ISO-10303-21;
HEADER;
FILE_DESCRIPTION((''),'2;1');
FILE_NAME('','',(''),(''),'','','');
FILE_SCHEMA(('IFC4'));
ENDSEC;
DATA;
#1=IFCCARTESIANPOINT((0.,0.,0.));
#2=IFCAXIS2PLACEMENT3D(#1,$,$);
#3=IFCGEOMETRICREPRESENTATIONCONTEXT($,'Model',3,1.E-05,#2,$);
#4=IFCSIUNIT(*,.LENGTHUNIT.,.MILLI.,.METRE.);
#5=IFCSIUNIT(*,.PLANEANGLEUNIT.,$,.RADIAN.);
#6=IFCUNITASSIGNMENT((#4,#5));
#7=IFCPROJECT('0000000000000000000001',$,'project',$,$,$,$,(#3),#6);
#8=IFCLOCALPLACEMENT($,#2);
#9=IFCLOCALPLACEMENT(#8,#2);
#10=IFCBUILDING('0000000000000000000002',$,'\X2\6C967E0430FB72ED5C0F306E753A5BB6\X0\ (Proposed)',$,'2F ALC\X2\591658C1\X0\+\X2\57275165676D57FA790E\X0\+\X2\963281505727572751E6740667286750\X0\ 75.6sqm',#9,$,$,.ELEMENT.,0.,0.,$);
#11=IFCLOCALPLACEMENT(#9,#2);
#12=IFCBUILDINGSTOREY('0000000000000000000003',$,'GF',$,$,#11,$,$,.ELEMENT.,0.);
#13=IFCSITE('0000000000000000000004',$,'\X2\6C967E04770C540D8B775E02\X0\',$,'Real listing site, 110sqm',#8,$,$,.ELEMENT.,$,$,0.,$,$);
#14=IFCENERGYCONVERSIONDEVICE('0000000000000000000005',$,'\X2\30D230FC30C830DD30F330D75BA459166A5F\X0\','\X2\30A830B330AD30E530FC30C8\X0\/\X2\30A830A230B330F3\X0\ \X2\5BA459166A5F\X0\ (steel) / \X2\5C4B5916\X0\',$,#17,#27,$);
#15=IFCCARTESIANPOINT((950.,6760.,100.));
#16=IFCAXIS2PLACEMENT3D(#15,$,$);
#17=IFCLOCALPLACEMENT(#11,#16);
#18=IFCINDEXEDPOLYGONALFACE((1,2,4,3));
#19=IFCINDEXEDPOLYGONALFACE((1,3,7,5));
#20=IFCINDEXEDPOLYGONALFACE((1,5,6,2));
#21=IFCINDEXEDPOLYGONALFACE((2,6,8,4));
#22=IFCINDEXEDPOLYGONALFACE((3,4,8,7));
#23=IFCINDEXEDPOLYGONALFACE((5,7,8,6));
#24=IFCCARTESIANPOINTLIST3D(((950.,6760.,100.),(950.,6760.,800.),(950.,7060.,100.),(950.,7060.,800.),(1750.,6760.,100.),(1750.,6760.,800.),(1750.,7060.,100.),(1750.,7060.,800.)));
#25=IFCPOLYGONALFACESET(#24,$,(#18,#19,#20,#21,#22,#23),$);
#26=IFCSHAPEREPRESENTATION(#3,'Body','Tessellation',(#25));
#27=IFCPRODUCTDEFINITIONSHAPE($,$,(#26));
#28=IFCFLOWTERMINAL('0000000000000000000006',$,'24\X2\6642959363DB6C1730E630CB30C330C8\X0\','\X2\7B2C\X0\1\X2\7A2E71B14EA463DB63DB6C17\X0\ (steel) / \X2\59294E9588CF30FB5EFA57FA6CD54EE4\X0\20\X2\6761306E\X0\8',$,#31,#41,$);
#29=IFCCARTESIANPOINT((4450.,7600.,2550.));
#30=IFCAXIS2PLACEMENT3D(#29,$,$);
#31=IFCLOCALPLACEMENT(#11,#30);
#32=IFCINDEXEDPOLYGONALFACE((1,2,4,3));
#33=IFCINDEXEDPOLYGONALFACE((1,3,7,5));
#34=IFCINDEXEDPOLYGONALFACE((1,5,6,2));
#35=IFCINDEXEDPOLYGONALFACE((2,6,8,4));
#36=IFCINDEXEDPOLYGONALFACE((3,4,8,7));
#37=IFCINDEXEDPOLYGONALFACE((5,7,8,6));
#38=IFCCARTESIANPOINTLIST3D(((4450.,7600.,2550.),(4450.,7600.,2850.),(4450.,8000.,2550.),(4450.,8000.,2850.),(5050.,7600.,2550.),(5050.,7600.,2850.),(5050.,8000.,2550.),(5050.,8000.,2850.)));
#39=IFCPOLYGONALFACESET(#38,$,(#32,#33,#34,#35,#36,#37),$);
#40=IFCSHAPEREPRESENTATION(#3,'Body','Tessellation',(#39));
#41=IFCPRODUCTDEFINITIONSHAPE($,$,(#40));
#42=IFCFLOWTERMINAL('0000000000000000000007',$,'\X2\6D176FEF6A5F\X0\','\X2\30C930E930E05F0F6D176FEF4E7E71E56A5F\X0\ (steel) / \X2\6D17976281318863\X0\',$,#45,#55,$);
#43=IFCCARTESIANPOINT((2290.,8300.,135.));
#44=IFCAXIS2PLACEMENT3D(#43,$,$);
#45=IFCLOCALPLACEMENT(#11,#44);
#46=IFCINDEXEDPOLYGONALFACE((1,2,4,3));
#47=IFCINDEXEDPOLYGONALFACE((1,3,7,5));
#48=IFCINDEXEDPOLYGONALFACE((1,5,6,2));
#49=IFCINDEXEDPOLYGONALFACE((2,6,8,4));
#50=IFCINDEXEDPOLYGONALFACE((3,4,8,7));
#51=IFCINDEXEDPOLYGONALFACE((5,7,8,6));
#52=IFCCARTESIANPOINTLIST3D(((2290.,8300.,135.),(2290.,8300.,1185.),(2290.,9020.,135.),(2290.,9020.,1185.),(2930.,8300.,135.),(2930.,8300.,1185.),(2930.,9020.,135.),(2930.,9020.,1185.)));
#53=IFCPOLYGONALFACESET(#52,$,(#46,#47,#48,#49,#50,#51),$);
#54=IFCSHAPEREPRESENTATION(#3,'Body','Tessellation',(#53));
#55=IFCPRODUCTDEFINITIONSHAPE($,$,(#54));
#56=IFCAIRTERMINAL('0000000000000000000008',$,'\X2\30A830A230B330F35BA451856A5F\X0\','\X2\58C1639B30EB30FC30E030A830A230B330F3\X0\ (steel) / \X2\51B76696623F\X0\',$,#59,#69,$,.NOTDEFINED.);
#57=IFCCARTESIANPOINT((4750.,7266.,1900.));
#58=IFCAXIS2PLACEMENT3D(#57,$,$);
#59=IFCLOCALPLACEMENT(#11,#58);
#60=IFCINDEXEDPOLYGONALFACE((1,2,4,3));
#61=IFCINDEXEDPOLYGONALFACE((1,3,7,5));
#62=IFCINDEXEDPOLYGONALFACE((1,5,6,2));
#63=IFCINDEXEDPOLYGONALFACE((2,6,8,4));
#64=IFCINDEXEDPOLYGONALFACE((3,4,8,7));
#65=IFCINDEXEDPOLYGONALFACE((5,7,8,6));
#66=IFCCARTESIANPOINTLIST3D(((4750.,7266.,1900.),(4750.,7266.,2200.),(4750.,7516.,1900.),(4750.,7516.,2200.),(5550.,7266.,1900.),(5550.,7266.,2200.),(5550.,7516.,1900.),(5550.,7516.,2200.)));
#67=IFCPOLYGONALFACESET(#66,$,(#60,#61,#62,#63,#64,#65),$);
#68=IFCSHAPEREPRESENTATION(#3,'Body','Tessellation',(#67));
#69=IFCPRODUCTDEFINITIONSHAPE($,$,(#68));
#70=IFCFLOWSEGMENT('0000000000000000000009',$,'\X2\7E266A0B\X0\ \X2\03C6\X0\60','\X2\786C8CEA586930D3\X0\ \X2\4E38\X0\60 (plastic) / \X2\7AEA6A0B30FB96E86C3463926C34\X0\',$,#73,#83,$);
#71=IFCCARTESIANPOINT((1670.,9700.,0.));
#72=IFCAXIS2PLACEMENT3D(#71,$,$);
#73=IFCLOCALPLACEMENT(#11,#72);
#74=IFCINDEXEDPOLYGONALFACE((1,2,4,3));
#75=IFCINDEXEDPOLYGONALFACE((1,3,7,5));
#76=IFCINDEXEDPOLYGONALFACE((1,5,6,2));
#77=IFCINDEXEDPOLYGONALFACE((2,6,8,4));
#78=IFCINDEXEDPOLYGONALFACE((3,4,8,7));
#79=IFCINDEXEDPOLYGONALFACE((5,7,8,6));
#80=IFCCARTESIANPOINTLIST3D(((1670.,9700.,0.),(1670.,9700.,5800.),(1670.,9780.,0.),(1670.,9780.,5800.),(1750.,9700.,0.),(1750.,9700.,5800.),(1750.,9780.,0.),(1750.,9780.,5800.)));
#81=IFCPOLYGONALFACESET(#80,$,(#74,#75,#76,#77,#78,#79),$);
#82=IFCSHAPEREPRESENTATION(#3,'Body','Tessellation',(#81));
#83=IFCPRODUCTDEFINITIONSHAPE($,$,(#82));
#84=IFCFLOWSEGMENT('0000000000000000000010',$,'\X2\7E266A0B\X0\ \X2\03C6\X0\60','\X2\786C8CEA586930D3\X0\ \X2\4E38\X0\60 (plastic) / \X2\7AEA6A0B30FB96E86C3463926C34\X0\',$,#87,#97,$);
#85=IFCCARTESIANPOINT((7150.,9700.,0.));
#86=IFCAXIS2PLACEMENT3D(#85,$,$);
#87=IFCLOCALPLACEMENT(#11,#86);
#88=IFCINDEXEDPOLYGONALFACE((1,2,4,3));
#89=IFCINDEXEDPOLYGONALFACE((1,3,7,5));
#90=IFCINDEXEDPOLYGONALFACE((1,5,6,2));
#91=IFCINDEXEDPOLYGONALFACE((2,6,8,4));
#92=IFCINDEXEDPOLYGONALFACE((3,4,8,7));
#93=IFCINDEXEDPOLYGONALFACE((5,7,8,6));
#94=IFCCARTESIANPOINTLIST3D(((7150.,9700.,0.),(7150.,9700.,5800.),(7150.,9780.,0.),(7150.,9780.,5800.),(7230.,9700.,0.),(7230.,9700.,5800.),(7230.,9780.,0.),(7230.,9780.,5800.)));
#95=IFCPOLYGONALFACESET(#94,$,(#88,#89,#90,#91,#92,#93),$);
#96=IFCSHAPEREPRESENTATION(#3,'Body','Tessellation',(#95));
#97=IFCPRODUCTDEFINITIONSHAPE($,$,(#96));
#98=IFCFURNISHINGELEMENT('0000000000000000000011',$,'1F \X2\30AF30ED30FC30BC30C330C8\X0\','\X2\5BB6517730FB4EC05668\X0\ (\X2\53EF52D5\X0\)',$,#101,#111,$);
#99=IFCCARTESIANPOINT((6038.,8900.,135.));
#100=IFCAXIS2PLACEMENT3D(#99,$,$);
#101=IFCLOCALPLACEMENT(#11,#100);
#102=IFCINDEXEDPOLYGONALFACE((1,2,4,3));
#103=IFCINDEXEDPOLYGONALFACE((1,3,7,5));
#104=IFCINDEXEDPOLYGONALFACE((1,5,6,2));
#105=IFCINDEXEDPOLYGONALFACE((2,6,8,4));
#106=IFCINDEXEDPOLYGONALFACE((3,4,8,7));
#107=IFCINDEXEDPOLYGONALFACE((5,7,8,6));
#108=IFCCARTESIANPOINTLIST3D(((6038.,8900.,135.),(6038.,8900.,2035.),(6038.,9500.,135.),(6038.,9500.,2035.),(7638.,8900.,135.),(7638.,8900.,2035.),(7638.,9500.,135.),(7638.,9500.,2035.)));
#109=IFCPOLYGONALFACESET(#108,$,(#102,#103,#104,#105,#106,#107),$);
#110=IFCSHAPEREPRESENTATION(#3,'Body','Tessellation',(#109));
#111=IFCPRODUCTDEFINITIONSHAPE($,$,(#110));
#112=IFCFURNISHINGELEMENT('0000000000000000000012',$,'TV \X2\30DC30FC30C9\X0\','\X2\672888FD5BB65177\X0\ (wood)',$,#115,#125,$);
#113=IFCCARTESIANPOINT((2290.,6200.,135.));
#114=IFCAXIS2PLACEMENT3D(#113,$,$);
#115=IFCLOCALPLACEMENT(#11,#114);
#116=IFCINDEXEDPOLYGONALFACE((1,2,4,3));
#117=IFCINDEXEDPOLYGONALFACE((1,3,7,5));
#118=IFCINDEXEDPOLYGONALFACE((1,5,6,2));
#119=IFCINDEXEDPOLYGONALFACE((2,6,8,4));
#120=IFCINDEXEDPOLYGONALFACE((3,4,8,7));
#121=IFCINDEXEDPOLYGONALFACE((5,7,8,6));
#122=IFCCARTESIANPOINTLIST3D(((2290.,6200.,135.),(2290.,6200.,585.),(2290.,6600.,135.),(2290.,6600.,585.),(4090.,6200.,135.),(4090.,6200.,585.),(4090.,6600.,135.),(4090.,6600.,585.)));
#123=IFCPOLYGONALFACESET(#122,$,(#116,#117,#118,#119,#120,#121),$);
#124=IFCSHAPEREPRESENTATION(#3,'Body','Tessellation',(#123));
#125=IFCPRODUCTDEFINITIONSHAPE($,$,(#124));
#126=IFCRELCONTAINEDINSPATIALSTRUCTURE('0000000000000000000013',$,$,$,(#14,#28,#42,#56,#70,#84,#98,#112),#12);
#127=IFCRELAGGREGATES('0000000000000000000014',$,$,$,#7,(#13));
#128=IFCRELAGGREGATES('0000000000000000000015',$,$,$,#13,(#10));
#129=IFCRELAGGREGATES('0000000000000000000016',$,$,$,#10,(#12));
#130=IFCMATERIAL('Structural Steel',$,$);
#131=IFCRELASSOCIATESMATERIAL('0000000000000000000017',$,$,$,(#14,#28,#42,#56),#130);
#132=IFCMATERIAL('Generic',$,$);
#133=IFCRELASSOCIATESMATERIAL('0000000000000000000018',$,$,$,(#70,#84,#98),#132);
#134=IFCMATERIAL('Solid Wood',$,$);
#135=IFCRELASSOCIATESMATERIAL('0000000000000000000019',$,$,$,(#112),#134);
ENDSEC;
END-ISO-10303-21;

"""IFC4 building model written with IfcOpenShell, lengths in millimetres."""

from ifc_helpers import new_model, si_unit, frame, frame_2d, origin, place, context, project, spatial, rectangle, extrude, material, element, save


model = new_model("IFC4")

# Units and contexts
model_context = context("Model", 3, precision=1e-05, world=origin())
ifc_project = project(units=[si_unit("LENGTHUNIT", "METRE", prefix="MILLI"), si_unit("PLANEANGLEUNIT", "RADIAN")], contexts=[model_context])

# Site, building, storey
site_placement = place(None, origin())
site = spatial("IfcSite", under=ifc_project, at=site_placement, Name="沖縄県名護市", ObjectType="Real listing site, 110sqm", CompositionType="ELEMENT", RefElevation=0.0)
building_placement = place(site_placement, origin())
building = spatial("IfcBuilding", under=site, at=building_placement, Name="沖縄・狭小の町家 (Proposed)", ObjectType="2F ALC外壁+圧入杭基礎+防腐圧圧処理木材 75.6sqm", CompositionType="ELEMENT", ElevationOfRefHeight=0.0, ElevationOfTerrain=0.0)
storey_placement = place(building_placement, origin())
storey = spatial("IfcBuildingStorey", under=building, at=storey_placement, Name="GF", CompositionType="ELEMENT", Elevation=0.0)

# Shared definitions
ifc_material_1 = material(Name="Solid Wood")

# Shared definitions
ifc_material_2 = material(Name="Generic")

# Shared definitions
ifc_material_3 = material(Name="Structural Steel")

# Energy conversion device
energy_conversion_device_placement = place(storey_placement, frame((950.0, 6760.0, 100.0)))
element("IfcEnergyConversionDevice", 1, at=energy_conversion_device_placement, inside=storey, material=ifc_material_3, Name="ヒートポンプ室外機", Description="エコキュート/エアコン 室外機 (steel) / 屋外", context=model_context, shape_type="SweptSolid", body=[
    extrude(rectangle(XDim=800.0, YDim=300.0, at=frame_2d((400.0, 150.0))), frame((950.0, 6760.0, 100.0)), (0.0, 0.0, 1.0), 700.0),
])

# Flow terminals
flow_terminal_1_placement = place(storey_placement, frame((4450.0, 7600.0, 2550.0)))
element("IfcFlowTerminal", 2, at=flow_terminal_1_placement, inside=storey, material=ifc_material_3, Name="24時間換気ユニット", Description="第1種熱交換換気 (steel) / 天井裏・建基法令20条の8", context=model_context, shape_type="SweptSolid", body=[
    extrude(rectangle(XDim=600.0, YDim=400.0, at=frame_2d((300.0, 200.0))), frame((4450.0, 7600.0, 2550.0)), (0.0, 0.0, 1.0), 300.0),
])
flow_terminal_2_placement = place(storey_placement, frame((2290.0, 8300.0, 135.0)))
element("IfcFlowTerminal", 3, at=flow_terminal_2_placement, inside=storey, material=ifc_material_3, Name="洗濯機", Description="ドラム式洗濯乾燥機 (steel) / 洗面脱衣", context=model_context, shape_type="SweptSolid", body=[
    extrude(rectangle(XDim=640.0, YDim=720.0, at=frame_2d((320.0, 360.0))), frame((2290.0, 8300.0, 135.0)), (0.0, 0.0, 1.0), 1050.0),
])

# Air terminal
air_terminal_placement = place(storey_placement, frame((4750.0, 7266.0, 1900.0)))
element("IfcAirTerminal", 4, at=air_terminal_placement, inside=storey, material=ifc_material_3, Name="エアコン室内機", Description="壁掛ルームエアコン (steel) / 冷暖房", PredefinedType="NOTDEFINED", context=model_context, shape_type="SweptSolid", body=[
    extrude(rectangle(XDim=800.0, YDim=250.0, at=frame_2d((400.0, 125.0))), frame((4750.0, 7266.0, 1900.0)), (0.0, 0.0, 1.0), 300.0),
])

# Flow segments
flow_segment_1_placement = place(storey_placement, frame((1670.0, 9700.0, 0.0)))
element("IfcFlowSegment", 5, at=flow_segment_1_placement, inside=storey, material=ifc_material_2, Name="縦樋 φ60", Description="硬質塩ビ 丸60 (plastic) / 竪樋・雨水排水", context=model_context, shape_type="SweptSolid", body=[
    extrude(rectangle(XDim=80.0, YDim=80.0, at=frame_2d((40.0, 40.0))), frame((1670.0, 9700.0, 0.0)), (0.0, 0.0, 1.0), 5800.0),
])
flow_segment_2_placement = place(storey_placement, frame((7150.0, 9700.0, 0.0)))
element("IfcFlowSegment", 6, at=flow_segment_2_placement, inside=storey, material=ifc_material_2, Name="縦樋 φ60", Description="硬質塩ビ 丸60 (plastic) / 竪樋・雨水排水", context=model_context, shape_type="SweptSolid", body=[
    extrude(rectangle(XDim=80.0, YDim=80.0, at=frame_2d((40.0, 40.0))), frame((7150.0, 9700.0, 0.0)), (0.0, 0.0, 1.0), 5800.0),
])

# Furnishing elements
furnishing_1_placement = place(storey_placement, frame((6038.0, 8900.0, 135.0)))
element("IfcFurnishingElement", 7, at=furnishing_1_placement, inside=storey, material=ifc_material_2, Name="1F クローゼット", Description="家具・什器 (可動)", context=model_context, shape_type="SweptSolid", body=[
    extrude(rectangle(XDim=1600.0, YDim=600.0, at=frame_2d((800.0, 300.0))), frame((6038.0, 8900.0, 135.0)), (0.0, 0.0, 1.0), 1900.0),
])
furnishing_2_placement = place(storey_placement, frame((2290.0, 6200.0, 135.0)))
element("IfcFurnishingElement", 8, at=furnishing_2_placement, inside=storey, material=ifc_material_1, Name="TV ボード", Description="木製家具 (wood)", context=model_context, shape_type="SweptSolid", body=[
    extrude(rectangle(XDim=1800.0, YDim=400.0, at=frame_2d((900.0, 200.0))), frame((2290.0, 6200.0, 135.0)), (0.0, 0.0, 1.0), 450.0),
])

save(model, "model.ifc")
